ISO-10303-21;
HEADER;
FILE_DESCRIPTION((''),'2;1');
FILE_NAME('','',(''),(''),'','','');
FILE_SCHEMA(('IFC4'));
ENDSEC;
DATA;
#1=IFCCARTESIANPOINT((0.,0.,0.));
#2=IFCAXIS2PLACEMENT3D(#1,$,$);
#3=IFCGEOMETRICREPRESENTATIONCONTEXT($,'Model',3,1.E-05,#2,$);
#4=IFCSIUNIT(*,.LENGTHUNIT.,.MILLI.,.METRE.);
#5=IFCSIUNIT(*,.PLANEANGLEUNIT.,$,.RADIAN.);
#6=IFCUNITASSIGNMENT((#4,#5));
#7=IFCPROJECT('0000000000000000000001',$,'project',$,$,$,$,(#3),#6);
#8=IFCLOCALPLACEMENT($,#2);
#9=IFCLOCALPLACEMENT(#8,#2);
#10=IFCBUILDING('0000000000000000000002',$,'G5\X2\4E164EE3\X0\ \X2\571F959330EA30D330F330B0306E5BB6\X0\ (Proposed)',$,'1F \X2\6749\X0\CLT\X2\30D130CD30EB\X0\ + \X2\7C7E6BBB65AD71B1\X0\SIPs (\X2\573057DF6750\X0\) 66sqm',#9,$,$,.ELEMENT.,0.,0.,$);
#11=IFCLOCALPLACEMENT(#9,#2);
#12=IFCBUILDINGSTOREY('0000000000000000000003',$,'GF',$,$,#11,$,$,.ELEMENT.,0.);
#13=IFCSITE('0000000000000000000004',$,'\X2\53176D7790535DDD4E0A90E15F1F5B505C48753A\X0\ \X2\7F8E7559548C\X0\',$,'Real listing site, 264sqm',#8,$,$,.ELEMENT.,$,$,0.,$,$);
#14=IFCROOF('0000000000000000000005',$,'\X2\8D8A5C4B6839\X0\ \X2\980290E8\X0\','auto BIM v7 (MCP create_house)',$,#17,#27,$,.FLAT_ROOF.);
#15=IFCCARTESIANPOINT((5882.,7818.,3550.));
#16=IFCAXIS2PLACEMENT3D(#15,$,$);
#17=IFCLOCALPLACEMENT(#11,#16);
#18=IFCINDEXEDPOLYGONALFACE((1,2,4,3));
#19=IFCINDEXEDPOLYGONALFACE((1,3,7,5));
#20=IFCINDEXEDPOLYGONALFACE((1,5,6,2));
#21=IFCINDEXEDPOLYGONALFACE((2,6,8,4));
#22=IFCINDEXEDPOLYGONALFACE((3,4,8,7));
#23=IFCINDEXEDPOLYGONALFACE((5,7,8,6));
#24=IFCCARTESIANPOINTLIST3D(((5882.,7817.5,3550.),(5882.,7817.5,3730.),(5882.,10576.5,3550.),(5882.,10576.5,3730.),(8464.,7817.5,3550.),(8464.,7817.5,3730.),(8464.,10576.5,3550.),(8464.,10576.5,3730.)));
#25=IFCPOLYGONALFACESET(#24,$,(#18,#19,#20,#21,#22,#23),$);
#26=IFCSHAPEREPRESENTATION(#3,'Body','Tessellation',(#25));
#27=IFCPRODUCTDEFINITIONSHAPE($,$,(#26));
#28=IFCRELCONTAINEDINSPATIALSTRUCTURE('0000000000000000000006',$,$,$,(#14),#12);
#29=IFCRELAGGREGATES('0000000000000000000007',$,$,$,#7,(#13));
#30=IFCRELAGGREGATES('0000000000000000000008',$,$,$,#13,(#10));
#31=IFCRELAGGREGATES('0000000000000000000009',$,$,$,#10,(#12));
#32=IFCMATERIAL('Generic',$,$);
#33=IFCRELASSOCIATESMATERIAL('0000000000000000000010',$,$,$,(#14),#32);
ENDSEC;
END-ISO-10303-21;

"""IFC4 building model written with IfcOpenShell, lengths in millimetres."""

from ifc_helpers import new_model, si_unit, frame, frame_2d, origin, place, context, project, spatial, rectangle, extrude, material, element, save


model = new_model("IFC4")

# Units and contexts
model_context = context("Model", 3, precision=1e-05, world=origin())
ifc_project = project(units=[si_unit("LENGTHUNIT", "METRE", prefix="MILLI"), si_unit("PLANEANGLEUNIT", "RADIAN")], contexts=[model_context])

# Site, building, storey
site_placement = place(None, origin())
site = spatial("IfcSite", under=ifc_project, at=site_placement, Name="北海道川上郡弟子屈町 美留和", ObjectType="Real listing site, 264sqm", CompositionType="ELEMENT", RefElevation=0.0)
building_placement = place(site_placement, origin())
building = spatial("IfcBuilding", under=site, at=building_placement, Name="G5世代 土間リビングの家 (Proposed)", ObjectType="1F 杉CLTパネル + 籾殻断熱SIPs (地域材) 66sqm", CompositionType="ELEMENT", ElevationOfRefHeight=0.0, ElevationOfTerrain=0.0)
storey_placement = place(building_placement, origin())
storey = spatial("IfcBuildingStorey", under=building, at=storey_placement, Name="GF", CompositionType="ELEMENT", Elevation=0.0)

# Shared definitions
ifc_material = material(Name="Generic")

# Roof
roof_1_placement = place(storey_placement, frame((5882.0, 7818.0, 3550.0)))
element("IfcRoof", 1, at=roof_1_placement, inside=storey, material=ifc_material, Name="越屋根 頂部", Description="auto BIM v7 (MCP create_house)", PredefinedType="FLAT_ROOF", context=model_context, shape_type="SweptSolid", body=[
    extrude(rectangle(XDim=2582.0, YDim=2759.0, at=frame_2d((1291.0, 1379.0))), frame((5882.0, 7818.0, 3550.0)), (0.0, 0.0, 1.0), 180.0),
])

save(model, "model.ifc")
